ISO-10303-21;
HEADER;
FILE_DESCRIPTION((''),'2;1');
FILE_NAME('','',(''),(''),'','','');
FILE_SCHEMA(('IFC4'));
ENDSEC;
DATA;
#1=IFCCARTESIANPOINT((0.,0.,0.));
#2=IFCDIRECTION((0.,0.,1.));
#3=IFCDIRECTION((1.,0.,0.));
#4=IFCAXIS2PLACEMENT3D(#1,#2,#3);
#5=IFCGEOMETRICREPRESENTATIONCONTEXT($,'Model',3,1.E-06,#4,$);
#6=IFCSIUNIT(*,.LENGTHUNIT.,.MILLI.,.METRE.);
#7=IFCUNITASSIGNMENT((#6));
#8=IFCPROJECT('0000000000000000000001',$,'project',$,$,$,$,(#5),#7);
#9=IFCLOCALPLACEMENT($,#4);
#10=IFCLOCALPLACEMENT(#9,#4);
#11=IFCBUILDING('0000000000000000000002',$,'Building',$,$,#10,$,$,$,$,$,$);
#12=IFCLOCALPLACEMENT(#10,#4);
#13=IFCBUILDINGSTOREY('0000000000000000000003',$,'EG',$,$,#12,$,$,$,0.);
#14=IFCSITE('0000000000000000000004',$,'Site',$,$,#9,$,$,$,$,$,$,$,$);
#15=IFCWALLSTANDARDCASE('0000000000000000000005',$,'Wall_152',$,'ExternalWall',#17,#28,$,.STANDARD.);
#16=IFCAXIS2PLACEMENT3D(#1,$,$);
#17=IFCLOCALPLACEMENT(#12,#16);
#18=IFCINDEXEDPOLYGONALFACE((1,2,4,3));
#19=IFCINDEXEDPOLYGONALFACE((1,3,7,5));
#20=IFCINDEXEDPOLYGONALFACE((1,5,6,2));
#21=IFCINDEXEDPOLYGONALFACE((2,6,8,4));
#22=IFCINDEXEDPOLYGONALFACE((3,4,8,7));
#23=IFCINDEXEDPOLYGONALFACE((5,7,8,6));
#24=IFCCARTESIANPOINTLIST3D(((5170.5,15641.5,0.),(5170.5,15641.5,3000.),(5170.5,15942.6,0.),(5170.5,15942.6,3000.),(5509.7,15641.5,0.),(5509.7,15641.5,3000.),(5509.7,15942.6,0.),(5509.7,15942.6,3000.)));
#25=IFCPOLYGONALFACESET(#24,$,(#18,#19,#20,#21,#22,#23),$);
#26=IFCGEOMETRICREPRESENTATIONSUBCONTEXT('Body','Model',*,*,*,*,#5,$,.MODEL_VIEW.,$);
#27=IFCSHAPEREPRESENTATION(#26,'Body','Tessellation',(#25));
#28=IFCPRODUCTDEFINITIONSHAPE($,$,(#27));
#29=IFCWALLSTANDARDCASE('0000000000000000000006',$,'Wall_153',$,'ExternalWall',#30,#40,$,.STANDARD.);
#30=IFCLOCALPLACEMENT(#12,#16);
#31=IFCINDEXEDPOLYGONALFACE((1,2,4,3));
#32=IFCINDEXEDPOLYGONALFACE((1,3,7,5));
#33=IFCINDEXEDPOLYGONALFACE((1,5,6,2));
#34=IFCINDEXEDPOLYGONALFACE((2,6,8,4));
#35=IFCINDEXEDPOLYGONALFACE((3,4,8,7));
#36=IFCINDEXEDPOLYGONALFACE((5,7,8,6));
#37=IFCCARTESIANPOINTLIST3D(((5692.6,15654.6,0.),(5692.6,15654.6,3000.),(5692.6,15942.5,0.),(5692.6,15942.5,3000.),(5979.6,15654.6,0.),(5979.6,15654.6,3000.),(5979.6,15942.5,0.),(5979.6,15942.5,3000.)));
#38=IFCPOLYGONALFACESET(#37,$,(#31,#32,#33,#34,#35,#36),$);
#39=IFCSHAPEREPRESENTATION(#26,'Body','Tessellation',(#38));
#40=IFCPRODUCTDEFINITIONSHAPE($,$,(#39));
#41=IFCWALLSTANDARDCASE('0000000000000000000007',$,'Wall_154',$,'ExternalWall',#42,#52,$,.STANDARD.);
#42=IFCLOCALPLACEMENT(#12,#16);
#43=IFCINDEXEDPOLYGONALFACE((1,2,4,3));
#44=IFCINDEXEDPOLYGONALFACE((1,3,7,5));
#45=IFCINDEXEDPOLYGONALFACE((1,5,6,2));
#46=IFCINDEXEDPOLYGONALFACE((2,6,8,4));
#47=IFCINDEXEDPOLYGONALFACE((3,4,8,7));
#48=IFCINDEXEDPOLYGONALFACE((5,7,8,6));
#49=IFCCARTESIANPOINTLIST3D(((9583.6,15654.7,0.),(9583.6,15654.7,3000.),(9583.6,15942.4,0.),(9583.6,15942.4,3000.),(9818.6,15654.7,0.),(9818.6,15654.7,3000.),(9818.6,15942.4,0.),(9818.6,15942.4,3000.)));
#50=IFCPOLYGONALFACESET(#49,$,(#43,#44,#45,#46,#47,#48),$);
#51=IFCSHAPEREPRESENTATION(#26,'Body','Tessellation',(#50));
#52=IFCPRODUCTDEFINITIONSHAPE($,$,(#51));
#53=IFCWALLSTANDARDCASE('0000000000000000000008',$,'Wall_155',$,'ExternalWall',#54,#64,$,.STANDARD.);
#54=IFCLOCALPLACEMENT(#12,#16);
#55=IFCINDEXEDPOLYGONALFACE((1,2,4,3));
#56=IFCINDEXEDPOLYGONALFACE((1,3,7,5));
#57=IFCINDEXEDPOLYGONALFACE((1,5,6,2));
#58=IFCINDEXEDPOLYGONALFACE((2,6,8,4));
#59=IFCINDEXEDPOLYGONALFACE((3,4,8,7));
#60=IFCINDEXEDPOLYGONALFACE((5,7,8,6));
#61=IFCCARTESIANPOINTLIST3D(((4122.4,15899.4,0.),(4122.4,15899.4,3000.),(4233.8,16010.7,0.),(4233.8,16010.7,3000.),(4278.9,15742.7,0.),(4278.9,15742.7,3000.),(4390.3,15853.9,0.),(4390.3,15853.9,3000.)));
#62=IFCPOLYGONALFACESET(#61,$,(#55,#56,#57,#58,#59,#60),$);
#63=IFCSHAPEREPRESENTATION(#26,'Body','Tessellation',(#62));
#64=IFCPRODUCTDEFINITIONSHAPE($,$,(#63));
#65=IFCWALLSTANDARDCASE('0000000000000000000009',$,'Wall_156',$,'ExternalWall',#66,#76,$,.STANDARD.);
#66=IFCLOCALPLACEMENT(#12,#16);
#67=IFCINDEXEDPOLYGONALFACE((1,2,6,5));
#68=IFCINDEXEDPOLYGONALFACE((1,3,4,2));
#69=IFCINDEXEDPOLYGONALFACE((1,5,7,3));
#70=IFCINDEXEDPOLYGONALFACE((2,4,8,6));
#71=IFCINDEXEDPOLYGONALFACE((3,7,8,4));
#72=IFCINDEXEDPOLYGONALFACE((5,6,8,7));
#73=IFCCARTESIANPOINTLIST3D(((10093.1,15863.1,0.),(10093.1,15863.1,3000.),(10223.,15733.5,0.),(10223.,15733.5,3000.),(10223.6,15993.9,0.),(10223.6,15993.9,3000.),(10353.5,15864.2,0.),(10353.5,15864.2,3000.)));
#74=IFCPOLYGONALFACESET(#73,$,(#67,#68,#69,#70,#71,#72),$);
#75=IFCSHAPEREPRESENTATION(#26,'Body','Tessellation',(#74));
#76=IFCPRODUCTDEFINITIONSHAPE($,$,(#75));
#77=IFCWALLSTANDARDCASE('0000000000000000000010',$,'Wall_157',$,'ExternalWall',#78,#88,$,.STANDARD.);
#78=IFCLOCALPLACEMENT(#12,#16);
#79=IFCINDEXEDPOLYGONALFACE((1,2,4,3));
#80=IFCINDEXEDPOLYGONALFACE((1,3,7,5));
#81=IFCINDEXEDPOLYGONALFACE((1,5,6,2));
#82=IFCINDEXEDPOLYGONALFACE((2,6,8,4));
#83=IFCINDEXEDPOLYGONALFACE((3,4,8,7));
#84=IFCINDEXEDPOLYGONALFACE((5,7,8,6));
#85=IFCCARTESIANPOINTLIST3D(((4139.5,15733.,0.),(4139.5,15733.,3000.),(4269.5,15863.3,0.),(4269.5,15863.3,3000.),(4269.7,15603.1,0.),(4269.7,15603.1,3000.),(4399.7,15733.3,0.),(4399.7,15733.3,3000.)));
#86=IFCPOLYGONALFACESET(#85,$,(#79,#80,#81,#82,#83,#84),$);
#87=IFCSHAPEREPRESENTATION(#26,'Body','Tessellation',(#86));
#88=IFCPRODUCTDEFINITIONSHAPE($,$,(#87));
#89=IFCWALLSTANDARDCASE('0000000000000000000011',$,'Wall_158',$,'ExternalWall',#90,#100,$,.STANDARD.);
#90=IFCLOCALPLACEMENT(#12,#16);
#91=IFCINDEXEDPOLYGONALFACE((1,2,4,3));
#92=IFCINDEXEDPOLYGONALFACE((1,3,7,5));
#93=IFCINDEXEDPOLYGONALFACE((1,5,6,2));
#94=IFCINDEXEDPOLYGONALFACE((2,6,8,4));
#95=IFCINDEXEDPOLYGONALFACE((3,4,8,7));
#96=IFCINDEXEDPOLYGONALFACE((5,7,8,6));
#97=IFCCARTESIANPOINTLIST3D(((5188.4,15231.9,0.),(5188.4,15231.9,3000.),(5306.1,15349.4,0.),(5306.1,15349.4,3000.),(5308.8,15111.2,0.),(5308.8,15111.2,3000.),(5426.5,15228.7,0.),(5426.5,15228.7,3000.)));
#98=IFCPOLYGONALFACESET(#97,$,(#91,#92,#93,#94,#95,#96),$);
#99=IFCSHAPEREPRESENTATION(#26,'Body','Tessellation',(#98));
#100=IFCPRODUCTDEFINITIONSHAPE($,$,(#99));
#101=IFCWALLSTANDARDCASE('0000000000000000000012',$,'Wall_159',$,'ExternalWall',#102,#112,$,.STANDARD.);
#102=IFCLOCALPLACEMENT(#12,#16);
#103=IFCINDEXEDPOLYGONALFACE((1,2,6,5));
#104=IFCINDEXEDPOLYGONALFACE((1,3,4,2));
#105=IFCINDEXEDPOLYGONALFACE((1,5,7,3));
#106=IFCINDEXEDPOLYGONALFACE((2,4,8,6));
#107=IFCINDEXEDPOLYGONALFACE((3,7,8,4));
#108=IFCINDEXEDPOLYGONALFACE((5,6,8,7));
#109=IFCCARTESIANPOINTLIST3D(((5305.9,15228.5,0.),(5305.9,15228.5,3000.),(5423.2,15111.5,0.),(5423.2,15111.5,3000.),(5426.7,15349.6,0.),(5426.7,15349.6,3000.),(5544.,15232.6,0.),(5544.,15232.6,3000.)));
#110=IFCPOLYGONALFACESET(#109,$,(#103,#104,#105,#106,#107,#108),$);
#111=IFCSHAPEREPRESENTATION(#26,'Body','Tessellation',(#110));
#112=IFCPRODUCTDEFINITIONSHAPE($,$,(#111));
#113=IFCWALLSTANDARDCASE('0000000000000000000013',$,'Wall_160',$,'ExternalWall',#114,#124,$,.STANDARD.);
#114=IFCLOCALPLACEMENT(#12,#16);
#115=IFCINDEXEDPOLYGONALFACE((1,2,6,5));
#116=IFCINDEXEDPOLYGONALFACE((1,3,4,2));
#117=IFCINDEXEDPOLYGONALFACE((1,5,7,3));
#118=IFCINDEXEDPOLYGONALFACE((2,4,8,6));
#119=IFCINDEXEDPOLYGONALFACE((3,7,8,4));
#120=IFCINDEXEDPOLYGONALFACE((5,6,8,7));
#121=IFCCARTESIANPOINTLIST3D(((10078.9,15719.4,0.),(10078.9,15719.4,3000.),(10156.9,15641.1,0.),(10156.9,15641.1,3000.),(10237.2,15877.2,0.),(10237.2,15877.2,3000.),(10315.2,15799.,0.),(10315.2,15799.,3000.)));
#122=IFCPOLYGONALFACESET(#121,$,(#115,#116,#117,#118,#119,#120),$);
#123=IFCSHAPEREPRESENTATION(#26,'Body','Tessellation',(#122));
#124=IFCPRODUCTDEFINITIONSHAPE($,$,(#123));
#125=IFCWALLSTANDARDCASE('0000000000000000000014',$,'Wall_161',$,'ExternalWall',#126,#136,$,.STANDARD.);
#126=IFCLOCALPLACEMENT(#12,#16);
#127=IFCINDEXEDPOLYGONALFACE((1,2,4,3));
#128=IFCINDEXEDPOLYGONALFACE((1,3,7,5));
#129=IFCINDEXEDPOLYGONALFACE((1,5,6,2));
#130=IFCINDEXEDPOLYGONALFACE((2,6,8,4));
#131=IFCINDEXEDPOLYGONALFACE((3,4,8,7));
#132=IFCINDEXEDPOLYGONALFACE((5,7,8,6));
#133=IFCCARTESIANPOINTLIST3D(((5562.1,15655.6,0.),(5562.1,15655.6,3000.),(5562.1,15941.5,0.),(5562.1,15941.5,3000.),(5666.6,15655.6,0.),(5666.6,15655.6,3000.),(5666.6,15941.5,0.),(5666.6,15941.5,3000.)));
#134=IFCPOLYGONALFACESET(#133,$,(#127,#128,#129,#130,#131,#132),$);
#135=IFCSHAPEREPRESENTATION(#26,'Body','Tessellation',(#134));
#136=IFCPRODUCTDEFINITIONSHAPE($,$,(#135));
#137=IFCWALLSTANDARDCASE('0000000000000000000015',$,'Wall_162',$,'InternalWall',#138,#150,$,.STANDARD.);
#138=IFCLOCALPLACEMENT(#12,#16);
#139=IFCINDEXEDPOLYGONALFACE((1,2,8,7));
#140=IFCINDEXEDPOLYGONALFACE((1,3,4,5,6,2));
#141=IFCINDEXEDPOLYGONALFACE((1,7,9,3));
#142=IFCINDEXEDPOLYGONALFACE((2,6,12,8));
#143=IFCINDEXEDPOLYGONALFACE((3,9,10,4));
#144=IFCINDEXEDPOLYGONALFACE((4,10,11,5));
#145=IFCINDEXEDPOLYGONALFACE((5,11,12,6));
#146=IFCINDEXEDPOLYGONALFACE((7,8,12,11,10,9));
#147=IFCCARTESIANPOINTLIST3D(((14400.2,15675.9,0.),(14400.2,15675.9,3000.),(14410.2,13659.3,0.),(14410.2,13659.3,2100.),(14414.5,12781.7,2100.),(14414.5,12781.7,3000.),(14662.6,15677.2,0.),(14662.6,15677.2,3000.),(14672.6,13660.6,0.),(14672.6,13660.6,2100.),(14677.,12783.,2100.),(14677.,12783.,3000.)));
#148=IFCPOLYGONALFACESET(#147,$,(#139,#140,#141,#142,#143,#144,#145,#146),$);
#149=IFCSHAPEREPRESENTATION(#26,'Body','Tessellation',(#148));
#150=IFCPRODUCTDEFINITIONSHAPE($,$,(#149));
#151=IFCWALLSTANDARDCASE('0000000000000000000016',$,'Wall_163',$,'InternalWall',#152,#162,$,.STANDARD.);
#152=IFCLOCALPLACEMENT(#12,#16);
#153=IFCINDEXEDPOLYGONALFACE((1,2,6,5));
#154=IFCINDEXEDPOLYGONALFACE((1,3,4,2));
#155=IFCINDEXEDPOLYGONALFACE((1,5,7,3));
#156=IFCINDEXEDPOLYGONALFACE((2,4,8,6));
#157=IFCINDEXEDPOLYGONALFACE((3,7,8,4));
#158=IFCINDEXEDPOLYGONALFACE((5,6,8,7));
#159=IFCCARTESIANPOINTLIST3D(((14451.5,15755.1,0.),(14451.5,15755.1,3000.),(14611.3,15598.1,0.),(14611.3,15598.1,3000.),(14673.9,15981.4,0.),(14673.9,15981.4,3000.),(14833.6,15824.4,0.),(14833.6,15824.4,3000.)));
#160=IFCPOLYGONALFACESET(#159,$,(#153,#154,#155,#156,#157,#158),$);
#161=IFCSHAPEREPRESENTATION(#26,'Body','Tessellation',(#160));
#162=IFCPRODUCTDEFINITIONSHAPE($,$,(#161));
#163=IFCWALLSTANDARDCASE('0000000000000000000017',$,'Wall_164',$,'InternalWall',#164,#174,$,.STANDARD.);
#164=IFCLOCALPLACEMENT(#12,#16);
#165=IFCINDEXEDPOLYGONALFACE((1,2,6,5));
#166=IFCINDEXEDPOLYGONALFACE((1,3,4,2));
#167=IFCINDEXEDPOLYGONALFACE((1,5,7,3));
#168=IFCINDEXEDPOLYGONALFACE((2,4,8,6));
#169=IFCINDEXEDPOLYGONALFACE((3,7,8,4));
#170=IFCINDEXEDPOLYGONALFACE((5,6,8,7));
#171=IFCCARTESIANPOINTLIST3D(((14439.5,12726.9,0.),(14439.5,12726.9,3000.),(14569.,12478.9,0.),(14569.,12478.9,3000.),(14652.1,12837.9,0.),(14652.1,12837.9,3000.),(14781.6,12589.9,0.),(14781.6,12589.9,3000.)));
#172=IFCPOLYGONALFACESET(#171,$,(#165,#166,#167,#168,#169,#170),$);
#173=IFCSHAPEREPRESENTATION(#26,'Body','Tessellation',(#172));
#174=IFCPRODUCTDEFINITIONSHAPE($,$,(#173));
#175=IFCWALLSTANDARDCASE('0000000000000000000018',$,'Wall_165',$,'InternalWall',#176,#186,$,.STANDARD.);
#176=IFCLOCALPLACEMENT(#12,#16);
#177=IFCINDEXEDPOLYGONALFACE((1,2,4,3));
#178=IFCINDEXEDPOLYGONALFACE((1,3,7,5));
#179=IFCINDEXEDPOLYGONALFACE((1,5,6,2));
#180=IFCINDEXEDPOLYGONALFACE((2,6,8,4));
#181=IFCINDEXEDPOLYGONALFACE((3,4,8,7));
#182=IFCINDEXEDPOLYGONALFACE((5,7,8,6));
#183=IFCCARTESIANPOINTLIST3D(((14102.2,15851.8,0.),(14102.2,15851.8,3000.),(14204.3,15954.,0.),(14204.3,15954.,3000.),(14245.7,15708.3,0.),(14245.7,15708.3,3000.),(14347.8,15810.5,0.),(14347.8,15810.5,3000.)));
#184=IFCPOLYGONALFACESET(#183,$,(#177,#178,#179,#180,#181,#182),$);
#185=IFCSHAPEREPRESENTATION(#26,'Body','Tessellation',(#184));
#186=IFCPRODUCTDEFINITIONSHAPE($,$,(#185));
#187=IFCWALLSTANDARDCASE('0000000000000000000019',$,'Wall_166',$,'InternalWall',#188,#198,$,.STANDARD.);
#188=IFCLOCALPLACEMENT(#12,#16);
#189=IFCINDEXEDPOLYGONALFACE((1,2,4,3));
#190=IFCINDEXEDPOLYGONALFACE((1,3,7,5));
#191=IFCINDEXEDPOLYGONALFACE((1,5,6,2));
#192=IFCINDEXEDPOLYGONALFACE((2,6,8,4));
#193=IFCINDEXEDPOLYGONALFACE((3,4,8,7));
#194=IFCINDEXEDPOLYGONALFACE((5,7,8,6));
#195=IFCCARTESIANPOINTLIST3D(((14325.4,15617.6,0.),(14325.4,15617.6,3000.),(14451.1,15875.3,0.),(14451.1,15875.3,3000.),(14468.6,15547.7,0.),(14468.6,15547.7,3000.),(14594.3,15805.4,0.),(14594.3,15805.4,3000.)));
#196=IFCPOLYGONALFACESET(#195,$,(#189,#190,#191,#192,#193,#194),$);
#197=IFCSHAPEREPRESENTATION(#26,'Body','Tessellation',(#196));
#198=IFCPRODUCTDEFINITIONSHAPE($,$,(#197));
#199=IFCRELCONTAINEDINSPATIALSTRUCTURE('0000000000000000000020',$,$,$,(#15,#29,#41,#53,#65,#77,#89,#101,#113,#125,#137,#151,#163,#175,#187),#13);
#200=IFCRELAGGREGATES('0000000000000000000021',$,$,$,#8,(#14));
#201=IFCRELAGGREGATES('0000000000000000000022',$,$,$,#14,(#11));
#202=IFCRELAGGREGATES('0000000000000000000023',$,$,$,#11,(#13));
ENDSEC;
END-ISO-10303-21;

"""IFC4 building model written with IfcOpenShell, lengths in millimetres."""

from ifc_helpers import new_model, si_unit, frame, origin_with_axes, place, context, subcontext, project, spatial, rectangle, extrude, element, save


model = new_model("IFC4")

# Units and contexts
model_context = context("Model", 3, precision=1e-06, world=origin_with_axes())
body_context = subcontext(model_context, "Body", "Model", "MODEL_VIEW")
ifc_project = project(units=[si_unit("LENGTHUNIT", "METRE", prefix="MILLI")], contexts=[model_context])

# Site, building, storey
site_placement = place(None, origin_with_axes())
site = spatial("IfcSite", under=ifc_project, at=site_placement, Name="Site")
building_placement = place(site_placement, origin_with_axes())
building = spatial("IfcBuilding", under=site, at=building_placement, Name="Building")
storey_placement = place(building_placement, origin_with_axes())
storey = spatial("IfcBuildingStorey", under=building, at=storey_placement, Name="EG", Elevation=0.0)

# Walls
wall_1_placement = place(storey_placement, origin_with_axes())
element("IfcWallStandardCase", 1, at=wall_1_placement, inside=storey, Name="Wall_152", ObjectType="ExternalWall", PredefinedType="STANDARD", context=body_context, shape_type="SweptSolid", body=[
    extrude(rectangle(XDim=339.2, YDim=301.2), frame((5340.1, 15792.0, 0.0), z_axis=(0.0, 0.0, 1.0), x_axis=(1.0, 0.0, 0.0)), (0.0, 0.0, 1.0), 3000.0),
])
wall_2_placement = place(storey_placement, origin_with_axes())
element("IfcWallStandardCase", 2, at=wall_2_placement, inside=storey, Name="Wall_153", ObjectType="ExternalWall", PredefinedType="STANDARD", context=body_context, shape_type="SweptSolid", body=[
    extrude(rectangle(XDim=287.0, YDim=288.0), frame((5836.1, 15798.5, 0.0), z_axis=(0.0, 0.0, 1.0), x_axis=(1.0, 0.0, 0.0)), (0.0, 0.0, 1.0), 3000.0),
])
wall_3_placement = place(storey_placement, origin_with_axes())
element("IfcWallStandardCase", 3, at=wall_3_placement, inside=storey, Name="Wall_154", ObjectType="ExternalWall", PredefinedType="STANDARD", context=body_context, shape_type="SweptSolid", body=[
    extrude(rectangle(XDim=235.0, YDim=287.8), frame((9701.1, 15798.5, 0.0), z_axis=(0.0, 0.0, 1.0), x_axis=(1.0, 0.0, 0.0)), (0.0, 0.0, 1.0), 3000.0),
])
wall_4_placement = place(storey_placement, origin_with_axes())
element("IfcWallStandardCase", 4, at=wall_4_placement, inside=storey, Name="Wall_155", ObjectType="ExternalWall", PredefinedType="STANDARD", context=body_context, shape_type="SweptSolid", body=[
    extrude(rectangle(XDim=221.5, YDim=157.5), frame((4256.3, 15876.7, 0.0), z_axis=(0.0, 0.0, 1.0), x_axis=(-0.706542, 0.707671, 0.0)), (0.0, 0.0, 1.0), 3000.0),
])
wall_5_placement = place(storey_placement, origin_with_axes())
element("IfcWallStandardCase", 5, at=wall_5_placement, inside=storey, Name="Wall_156", ObjectType="ExternalWall", PredefinedType="STANDARD", context=body_context, shape_type="SweptSolid", body=[
    extrude(rectangle(XDim=184.7, YDim=183.5), frame((10223.3, 15863.7, 0.0), z_axis=(0.0, 0.0, 1.0), x_axis=(0.70643, 0.707783, 0.0)), (0.0, 0.0, 1.0), 3000.0),
])
wall_6_placement = place(storey_placement, origin_with_axes())
element("IfcWallStandardCase", 6, at=wall_6_placement, inside=storey, Name="Wall_157", ObjectType="ExternalWall", PredefinedType="STANDARD", context=body_context, shape_type="SweptSolid", body=[
    extrude(rectangle(XDim=184.0, YDim=184.0), frame((4269.6, 15733.2, 0.0), z_axis=(0.0, 0.0, 1.0), x_axis=(-0.706427, -0.707786, 0.0)), (0.0, 0.0, 1.0), 3000.0),
])
wall_7_placement = place(storey_placement, origin_with_axes())
element("IfcWallStandardCase", 7, at=wall_7_placement, inside=storey, Name="Wall_158", ObjectType="ExternalWall", PredefinedType="STANDARD", context=body_context, shape_type="SweptSolid", body=[
    extrude(rectangle(XDim=166.3, YDim=170.5), frame((5307.5, 15230.3, 0.0), z_axis=(0.0, 0.0, 1.0), x_axis=(-0.707858, -0.706355, 0.0)), (0.0, 0.0, 1.0), 3000.0),
])
wall_8_placement = place(storey_placement, origin_with_axes())
element("IfcWallStandardCase", 8, at=wall_8_placement, inside=storey, Name="Wall_159", ObjectType="ExternalWall", PredefinedType="STANDARD", context=body_context, shape_type="SweptSolid", body=[
    extrude(rectangle(XDim=165.6, YDim=171.0), frame((5425.0, 15230.5, 0.0), z_axis=(0.0, 0.0, 1.0), x_axis=(0.707861, -0.706352, 0.0)), (0.0, 0.0, 1.0), 3000.0),
])
wall_9_placement = place(storey_placement, origin_with_axes())
element("IfcWallStandardCase", 9, at=wall_9_placement, inside=storey, Name="Wall_160", ObjectType="ExternalWall", PredefinedType="STANDARD", context=body_context, shape_type="SweptSolid", body=[
    extrude(rectangle(XDim=110.5, YDim=223.5), frame((10197.1, 15759.2, 0.0), z_axis=(0.0, 0.0, 1.0), x_axis=(0.705975, -0.708237, 0.0)), (0.0, 0.0, 1.0), 3000.0),
])
wall_10_placement = place(storey_placement, origin_with_axes())
element("IfcWallStandardCase", 10, at=wall_10_placement, inside=storey, Name="Wall_161", ObjectType="ExternalWall", PredefinedType="STANDARD", context=body_context, shape_type="SweptSolid", body=[
    extrude(rectangle(XDim=104.5, YDim=285.8), frame((5614.3, 15798.5, 0.0), z_axis=(0.0, 0.0, 1.0), x_axis=(1.0, 0.0, 0.0)), (0.0, 0.0, 1.0), 3000.0),
])

# Wall, opening
wall_11_placement = place(storey_placement, origin_with_axes())
wall_11 = element("IfcWallStandardCase", 11, at=wall_11_placement, inside=storey, Name="Wall_162", ObjectType="InternalWall", PredefinedType="STANDARD", context=body_context, shape_type="SweptSolid", body=[
    extrude(rectangle(XDim=2894.2, YDim=262.4), frame((14538.6, 14229.5, 0.0), z_axis=(0.0, 0.0, 1.0), x_axis=(0.004952, -0.999988, 0.0)), (0.0, 0.0, 1.0), 3000.0),
])
opening_1_placement = place(wall_11_placement, origin_with_axes())
element("IfcOpeningElement", 12, at=opening_1_placement, inside=storey, cuts=wall_11, context=body_context, shape_type="SweptSolid", body=[
    extrude(rectangle(XDim=877.6, YDim=262.4), frame((14543.6, 13221.2, 0.0), z_axis=(0.0, 0.0, 1.0), x_axis=(0.004952, -0.999988, 0.0)), (0.0, 0.0, 1.0), 2100.0),
])

# Walls
wall_12_placement = place(storey_placement, origin_with_axes())
element("IfcWallStandardCase", 13, at=wall_12_placement, inside=storey, Name="Wall_163", ObjectType="InternalWall", PredefinedType="STANDARD", context=body_context, shape_type="SweptSolid", body=[
    extrude(rectangle(XDim=317.3, YDim=224.0), frame((14642.6, 15789.7, 0.0), z_axis=(0.0, 0.0, 1.0), x_axis=(0.700801, 0.713357, 0.0)), (0.0, 0.0, 1.0), 3000.0),
])
wall_13_placement = place(storey_placement, origin_with_axes())
element("IfcWallStandardCase", 14, at=wall_13_placement, inside=storey, Name="Wall_164", ObjectType="InternalWall", PredefinedType="STANDARD", context=body_context, shape_type="SweptSolid", body=[
    extrude(rectangle(XDim=279.8, YDim=239.8), frame((14610.5, 12658.4, 0.0), z_axis=(0.0, 0.0, 1.0), x_axis=(0.462908, -0.886406, 0.0)), (0.0, 0.0, 1.0), 3000.0),
])
wall_14_placement = place(storey_placement, origin_with_axes())
element("IfcWallStandardCase", 15, at=wall_14_placement, inside=storey, Name="Wall_165", ObjectType="InternalWall", PredefinedType="STANDARD", context=body_context, shape_type="SweptSolid", body=[
    extrude(rectangle(XDim=202.9, YDim=144.5), frame((14225.0, 15831.2, 0.0), z_axis=(0.0, 0.0, 1.0), x_axis=(-0.707107, 0.707107, 0.0)), (0.0, 0.0, 1.0), 3000.0),
])
wall_15_placement = place(storey_placement, origin_with_axes())
element("IfcWallStandardCase", 16, at=wall_15_placement, inside=storey, Name="Wall_166", ObjectType="InternalWall", PredefinedType="STANDARD", context=body_context, shape_type="SweptSolid", body=[
    extrude(rectangle(XDim=159.3, YDim=286.7), frame((14459.8, 15711.5, 0.0), z_axis=(0.0, 0.0, 1.0), x_axis=(-0.89882, 0.438319, 0.0)), (0.0, 0.0, 1.0), 3000.0),
])

save(model, "model.ifc")
